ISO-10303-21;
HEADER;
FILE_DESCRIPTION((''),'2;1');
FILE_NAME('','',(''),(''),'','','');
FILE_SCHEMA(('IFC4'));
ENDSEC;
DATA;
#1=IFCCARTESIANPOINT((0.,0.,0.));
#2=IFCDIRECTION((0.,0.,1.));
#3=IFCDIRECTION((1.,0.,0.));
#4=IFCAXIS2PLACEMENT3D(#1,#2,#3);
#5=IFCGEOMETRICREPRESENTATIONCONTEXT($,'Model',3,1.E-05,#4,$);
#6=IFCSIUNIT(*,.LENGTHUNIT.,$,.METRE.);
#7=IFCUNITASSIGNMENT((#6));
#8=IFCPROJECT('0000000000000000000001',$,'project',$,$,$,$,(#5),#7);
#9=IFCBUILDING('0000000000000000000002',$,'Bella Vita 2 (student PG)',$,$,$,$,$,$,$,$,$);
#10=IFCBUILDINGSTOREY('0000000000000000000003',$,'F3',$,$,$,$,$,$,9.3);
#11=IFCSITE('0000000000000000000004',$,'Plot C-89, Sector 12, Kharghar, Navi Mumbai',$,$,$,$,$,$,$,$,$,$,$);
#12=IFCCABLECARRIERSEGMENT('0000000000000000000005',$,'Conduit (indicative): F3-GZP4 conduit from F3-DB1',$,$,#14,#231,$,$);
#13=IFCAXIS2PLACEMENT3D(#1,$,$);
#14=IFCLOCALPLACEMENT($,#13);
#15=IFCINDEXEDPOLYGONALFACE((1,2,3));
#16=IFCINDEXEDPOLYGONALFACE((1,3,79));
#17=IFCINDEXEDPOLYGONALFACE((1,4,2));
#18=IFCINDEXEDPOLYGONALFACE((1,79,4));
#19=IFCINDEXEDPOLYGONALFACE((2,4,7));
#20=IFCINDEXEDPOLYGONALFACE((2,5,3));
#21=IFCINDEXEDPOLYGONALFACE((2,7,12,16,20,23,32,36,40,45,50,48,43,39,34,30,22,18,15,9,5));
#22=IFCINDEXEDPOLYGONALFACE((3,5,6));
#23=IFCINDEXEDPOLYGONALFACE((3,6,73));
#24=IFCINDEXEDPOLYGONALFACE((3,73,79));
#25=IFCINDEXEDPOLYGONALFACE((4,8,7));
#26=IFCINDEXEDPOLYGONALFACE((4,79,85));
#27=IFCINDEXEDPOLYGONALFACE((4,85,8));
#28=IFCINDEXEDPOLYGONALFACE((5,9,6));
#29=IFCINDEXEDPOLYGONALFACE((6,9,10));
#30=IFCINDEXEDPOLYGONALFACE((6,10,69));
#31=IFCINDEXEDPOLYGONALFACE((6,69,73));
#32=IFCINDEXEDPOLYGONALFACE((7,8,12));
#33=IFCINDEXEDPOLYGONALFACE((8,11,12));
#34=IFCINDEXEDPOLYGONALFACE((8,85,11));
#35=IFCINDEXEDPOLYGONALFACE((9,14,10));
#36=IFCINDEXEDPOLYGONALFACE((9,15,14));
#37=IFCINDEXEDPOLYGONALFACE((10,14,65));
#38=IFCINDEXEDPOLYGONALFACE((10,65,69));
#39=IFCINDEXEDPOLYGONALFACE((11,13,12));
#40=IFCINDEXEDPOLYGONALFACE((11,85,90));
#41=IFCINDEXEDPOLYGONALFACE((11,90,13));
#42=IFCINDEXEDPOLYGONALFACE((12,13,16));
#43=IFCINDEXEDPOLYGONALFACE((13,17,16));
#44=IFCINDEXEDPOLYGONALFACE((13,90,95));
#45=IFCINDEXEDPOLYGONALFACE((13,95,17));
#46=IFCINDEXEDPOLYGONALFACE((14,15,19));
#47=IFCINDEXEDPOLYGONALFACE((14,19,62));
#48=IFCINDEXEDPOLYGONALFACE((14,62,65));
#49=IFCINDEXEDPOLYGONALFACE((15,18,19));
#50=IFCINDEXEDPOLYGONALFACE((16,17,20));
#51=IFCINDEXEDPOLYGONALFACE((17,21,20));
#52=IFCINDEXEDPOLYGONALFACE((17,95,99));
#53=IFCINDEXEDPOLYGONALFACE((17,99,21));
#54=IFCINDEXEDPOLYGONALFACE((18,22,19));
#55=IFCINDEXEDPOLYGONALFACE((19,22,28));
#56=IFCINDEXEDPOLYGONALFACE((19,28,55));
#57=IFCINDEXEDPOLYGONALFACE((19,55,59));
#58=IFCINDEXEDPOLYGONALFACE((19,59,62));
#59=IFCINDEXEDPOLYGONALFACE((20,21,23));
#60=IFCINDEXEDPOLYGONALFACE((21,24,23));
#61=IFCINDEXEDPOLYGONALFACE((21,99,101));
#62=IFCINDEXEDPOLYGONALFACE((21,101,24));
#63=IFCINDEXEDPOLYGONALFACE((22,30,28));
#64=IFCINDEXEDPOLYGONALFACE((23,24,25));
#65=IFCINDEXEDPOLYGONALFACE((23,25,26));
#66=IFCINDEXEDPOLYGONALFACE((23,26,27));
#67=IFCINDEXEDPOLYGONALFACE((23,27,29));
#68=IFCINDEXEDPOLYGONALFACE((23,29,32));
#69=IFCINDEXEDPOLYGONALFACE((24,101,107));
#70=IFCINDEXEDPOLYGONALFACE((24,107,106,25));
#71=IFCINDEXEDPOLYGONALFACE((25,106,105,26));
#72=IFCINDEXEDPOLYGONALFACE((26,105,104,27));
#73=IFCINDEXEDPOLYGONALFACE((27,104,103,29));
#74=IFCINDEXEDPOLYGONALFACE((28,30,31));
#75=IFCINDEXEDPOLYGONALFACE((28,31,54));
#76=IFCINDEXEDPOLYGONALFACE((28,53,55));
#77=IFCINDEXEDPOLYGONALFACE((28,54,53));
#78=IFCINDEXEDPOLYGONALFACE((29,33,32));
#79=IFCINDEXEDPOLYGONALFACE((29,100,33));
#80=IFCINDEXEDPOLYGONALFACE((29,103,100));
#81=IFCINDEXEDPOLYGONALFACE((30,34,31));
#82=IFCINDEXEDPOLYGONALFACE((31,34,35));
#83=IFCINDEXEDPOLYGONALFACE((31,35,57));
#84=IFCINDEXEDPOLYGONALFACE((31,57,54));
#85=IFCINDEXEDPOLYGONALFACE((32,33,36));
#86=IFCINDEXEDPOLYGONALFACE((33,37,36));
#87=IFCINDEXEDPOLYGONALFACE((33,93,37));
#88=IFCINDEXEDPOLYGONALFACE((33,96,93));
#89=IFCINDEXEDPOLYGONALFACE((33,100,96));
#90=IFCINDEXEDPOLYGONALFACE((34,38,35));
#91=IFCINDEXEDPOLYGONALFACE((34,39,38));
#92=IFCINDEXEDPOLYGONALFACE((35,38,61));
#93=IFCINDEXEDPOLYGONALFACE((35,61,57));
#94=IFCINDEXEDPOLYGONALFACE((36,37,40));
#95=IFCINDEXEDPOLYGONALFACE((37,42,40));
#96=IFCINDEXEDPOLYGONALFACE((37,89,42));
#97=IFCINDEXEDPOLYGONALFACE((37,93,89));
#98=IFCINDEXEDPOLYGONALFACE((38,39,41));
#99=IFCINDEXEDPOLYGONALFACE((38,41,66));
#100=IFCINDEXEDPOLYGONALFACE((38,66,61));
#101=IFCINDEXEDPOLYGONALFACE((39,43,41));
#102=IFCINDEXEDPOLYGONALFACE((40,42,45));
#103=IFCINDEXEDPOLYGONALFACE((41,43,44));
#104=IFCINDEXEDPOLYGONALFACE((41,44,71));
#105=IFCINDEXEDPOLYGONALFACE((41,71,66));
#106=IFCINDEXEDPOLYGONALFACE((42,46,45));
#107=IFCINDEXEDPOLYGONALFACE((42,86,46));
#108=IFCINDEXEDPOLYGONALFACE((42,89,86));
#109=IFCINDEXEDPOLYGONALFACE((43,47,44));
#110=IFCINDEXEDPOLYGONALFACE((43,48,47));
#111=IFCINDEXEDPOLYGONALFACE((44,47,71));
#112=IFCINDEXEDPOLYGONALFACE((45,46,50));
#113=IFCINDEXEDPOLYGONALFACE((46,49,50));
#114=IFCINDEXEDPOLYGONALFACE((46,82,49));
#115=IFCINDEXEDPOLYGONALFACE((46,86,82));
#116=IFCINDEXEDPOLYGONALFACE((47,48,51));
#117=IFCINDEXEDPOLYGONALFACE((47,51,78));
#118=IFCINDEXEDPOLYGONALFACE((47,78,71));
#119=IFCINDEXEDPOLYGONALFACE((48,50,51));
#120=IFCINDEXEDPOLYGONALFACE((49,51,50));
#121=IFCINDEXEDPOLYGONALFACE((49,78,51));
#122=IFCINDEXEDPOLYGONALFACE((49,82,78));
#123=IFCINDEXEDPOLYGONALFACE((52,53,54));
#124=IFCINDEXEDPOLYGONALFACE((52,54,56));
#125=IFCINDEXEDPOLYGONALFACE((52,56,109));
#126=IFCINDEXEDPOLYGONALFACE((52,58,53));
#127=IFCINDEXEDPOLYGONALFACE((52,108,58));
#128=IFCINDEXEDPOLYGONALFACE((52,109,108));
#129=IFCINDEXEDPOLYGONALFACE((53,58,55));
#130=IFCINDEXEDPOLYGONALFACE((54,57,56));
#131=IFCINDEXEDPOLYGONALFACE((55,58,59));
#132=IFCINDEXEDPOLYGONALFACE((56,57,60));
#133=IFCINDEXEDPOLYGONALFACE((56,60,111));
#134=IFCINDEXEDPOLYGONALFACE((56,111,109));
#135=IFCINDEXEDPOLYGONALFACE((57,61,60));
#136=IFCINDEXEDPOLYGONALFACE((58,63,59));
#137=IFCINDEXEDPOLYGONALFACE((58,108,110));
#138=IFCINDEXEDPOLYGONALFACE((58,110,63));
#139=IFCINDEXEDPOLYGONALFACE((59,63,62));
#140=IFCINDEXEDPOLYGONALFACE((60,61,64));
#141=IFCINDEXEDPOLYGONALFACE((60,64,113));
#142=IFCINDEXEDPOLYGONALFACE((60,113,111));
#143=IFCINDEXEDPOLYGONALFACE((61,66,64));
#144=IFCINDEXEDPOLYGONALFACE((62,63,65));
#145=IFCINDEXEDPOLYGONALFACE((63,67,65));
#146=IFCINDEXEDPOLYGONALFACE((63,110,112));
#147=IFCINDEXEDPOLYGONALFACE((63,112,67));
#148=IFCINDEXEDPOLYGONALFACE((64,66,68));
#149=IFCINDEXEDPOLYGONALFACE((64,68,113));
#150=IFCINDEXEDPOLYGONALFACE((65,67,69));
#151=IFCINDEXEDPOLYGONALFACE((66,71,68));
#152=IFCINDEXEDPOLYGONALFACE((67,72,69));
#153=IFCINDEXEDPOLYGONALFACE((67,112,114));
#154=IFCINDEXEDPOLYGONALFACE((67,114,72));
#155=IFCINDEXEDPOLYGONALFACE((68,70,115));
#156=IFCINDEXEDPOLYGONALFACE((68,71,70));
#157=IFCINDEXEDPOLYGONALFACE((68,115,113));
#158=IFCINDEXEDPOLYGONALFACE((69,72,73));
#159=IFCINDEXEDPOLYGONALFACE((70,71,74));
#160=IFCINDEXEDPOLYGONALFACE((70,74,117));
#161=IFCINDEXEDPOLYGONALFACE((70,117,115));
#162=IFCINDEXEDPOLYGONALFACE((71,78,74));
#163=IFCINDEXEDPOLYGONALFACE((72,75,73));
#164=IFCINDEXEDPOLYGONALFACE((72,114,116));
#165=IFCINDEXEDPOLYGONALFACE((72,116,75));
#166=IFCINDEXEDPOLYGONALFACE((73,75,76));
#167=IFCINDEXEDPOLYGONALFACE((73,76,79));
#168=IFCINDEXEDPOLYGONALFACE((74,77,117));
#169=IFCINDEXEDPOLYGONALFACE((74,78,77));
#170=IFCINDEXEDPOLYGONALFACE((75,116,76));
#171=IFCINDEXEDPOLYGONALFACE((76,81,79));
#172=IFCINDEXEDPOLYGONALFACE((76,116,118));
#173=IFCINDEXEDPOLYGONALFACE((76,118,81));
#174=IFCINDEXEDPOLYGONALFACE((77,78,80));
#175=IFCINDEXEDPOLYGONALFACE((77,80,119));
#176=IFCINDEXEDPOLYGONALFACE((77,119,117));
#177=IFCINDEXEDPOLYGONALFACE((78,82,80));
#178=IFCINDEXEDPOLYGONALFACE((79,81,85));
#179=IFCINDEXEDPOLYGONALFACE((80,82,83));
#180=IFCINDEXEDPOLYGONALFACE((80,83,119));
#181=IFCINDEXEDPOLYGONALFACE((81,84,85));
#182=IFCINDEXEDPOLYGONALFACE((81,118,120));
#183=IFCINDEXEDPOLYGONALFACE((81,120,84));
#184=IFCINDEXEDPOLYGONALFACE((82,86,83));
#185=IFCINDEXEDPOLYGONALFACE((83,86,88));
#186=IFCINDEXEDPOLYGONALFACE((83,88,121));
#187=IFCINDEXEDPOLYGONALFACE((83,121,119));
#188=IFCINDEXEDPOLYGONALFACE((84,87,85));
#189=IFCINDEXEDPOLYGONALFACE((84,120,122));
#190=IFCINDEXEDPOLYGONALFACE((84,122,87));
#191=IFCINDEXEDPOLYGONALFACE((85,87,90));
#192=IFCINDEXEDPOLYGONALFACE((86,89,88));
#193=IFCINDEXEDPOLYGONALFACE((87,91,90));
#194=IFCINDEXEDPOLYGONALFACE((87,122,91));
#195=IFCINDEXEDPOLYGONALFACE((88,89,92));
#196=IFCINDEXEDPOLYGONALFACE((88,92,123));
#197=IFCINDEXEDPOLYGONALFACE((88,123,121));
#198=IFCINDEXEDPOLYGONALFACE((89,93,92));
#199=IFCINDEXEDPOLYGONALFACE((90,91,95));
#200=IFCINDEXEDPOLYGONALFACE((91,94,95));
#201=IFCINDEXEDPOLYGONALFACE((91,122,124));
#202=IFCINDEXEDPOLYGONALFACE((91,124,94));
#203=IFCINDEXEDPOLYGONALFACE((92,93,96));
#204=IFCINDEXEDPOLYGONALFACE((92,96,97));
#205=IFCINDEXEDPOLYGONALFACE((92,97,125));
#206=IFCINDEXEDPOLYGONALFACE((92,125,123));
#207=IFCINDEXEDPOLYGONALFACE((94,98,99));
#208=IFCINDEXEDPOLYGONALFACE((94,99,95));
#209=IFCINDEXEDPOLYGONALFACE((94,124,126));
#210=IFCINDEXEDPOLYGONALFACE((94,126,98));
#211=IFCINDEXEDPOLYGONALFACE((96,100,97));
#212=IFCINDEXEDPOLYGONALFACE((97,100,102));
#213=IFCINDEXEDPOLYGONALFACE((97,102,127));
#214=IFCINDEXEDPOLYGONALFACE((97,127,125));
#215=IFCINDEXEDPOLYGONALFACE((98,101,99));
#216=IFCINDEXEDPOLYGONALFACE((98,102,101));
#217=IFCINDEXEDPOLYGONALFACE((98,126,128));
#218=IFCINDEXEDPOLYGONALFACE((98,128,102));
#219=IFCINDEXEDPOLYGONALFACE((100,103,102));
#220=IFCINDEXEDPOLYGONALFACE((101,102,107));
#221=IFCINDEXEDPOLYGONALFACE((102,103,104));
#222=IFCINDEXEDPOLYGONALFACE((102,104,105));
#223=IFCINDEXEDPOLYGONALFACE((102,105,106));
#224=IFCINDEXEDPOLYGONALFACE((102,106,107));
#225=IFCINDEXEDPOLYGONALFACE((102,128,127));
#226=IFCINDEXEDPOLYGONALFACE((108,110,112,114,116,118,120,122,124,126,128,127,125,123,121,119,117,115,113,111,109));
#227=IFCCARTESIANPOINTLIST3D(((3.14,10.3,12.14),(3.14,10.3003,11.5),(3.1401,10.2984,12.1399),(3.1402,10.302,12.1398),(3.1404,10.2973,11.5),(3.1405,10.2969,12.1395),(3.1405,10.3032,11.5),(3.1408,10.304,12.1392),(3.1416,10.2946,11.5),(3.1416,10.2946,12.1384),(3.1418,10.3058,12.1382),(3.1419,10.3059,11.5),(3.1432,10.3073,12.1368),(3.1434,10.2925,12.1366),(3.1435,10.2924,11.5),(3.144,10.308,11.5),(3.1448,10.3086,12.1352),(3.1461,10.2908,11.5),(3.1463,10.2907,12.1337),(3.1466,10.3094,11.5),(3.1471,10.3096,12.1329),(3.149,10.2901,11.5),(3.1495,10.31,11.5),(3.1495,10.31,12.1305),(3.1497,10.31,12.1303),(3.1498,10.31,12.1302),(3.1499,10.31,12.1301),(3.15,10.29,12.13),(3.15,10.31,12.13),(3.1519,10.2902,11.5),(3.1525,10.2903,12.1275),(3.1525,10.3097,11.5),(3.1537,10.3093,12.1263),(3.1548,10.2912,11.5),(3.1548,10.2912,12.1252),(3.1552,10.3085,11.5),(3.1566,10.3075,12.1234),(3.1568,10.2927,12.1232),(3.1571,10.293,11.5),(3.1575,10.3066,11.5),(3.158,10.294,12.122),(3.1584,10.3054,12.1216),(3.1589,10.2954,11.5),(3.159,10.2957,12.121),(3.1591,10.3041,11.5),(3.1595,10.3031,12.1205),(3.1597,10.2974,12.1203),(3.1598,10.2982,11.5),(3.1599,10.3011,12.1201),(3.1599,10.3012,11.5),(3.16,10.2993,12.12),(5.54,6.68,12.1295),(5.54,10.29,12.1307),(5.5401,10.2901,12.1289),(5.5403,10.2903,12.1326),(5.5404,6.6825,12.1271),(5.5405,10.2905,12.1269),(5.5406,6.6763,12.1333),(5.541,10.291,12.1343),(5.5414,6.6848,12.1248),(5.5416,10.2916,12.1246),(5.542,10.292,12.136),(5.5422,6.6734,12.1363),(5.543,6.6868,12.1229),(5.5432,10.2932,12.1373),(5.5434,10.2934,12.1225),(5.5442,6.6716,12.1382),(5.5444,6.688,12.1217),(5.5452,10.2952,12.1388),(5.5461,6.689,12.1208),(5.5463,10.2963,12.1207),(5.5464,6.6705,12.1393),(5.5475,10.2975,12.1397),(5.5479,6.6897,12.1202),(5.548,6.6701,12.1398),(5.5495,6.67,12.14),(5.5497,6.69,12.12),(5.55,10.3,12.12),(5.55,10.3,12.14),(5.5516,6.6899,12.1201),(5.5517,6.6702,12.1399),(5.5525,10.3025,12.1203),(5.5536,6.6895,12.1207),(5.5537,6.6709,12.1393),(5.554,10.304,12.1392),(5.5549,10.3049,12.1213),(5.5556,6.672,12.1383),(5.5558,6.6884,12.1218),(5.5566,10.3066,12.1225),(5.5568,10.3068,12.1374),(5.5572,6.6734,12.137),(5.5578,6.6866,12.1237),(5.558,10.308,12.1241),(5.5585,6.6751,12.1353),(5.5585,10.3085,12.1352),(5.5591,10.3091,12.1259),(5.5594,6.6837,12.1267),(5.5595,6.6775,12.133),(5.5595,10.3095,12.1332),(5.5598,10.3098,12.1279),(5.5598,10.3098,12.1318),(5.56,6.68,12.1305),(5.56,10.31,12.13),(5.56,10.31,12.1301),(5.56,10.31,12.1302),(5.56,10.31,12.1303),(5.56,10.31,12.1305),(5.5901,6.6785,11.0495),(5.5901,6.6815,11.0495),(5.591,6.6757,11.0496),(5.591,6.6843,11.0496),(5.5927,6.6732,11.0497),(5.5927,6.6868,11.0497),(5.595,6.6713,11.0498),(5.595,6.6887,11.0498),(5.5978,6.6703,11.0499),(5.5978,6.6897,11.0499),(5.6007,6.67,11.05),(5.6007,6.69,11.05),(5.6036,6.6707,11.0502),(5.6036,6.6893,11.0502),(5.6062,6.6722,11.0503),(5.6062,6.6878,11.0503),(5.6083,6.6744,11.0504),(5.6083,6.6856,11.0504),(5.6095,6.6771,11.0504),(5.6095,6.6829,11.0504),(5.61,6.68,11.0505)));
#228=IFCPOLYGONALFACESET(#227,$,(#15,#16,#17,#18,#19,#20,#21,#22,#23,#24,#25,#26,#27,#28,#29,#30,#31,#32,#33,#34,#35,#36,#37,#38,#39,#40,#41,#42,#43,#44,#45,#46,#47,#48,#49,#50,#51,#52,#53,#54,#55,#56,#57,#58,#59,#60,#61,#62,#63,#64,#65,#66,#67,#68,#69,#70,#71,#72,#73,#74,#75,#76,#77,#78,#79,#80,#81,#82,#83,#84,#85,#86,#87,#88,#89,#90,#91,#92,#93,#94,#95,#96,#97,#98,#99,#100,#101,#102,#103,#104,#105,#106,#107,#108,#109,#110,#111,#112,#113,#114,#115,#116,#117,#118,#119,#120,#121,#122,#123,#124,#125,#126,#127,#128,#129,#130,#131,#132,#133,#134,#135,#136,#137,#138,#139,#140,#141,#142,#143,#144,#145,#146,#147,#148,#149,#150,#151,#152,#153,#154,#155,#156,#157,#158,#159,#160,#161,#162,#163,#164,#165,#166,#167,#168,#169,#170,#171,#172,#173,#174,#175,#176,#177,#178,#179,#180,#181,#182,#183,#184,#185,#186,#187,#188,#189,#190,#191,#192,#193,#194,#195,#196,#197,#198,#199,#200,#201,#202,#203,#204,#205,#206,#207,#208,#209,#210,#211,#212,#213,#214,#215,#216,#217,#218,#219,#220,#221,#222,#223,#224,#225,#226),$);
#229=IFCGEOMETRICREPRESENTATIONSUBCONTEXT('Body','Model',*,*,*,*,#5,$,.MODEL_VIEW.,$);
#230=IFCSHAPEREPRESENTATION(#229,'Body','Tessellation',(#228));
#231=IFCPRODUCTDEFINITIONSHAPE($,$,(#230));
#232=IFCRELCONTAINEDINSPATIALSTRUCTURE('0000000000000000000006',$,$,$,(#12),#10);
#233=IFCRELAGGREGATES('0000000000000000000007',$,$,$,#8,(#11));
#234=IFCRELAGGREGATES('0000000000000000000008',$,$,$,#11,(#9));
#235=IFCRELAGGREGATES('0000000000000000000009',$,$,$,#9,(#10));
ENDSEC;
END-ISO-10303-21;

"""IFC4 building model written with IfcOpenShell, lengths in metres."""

from ifc_helpers import new_model, entity, si_unit, origin, origin_with_axes, place, context, subcontext, project, spatial, element, save


model = new_model("IFC4")

# Units and contexts
model_context = context("Model", 3, precision=1e-05, world=origin_with_axes())
body_context = subcontext(model_context, "Body", "Model", "MODEL_VIEW")
ifc_project = project(units=[si_unit("LENGTHUNIT", "METRE")], contexts=[model_context])

# Site, building, storey
site = spatial("IfcSite", under=ifc_project, Name="Plot C-89, Sector 12, Kharghar, Navi Mumbai")
building = spatial("IfcBuilding", under=site, Name="Bella Vita 2 (student PG)")
storey = spatial("IfcBuildingStorey", under=building, Name="F3", Elevation=9.3)

# Cable carrier segment
cable_carrier_segment_1_placement = place(None, origin())
element("IfcCableCarrierSegment", 1, at=cable_carrier_segment_1_placement, inside=storey, Name="Conduit (indicative): F3-GZP4 conduit from F3-DB1", context=body_context, shape_type="AdvancedSweptSolid", body=[
    entity("IfcSweptDiskSolid", entity("IfcPolyline", [entity("IfcCartesianPoint", [5.6, 6.68, 11.05]), entity("IfcCartesianPoint", [5.55, 6.68, 12.13]), entity("IfcCartesianPoint", [5.55, 10.3, 12.13]), entity("IfcCartesianPoint", [3.15, 10.3, 12.13]), entity("IfcCartesianPoint", [3.15, 10.3, 11.5])]), 0.01),
])

save(model, "model.ifc")
